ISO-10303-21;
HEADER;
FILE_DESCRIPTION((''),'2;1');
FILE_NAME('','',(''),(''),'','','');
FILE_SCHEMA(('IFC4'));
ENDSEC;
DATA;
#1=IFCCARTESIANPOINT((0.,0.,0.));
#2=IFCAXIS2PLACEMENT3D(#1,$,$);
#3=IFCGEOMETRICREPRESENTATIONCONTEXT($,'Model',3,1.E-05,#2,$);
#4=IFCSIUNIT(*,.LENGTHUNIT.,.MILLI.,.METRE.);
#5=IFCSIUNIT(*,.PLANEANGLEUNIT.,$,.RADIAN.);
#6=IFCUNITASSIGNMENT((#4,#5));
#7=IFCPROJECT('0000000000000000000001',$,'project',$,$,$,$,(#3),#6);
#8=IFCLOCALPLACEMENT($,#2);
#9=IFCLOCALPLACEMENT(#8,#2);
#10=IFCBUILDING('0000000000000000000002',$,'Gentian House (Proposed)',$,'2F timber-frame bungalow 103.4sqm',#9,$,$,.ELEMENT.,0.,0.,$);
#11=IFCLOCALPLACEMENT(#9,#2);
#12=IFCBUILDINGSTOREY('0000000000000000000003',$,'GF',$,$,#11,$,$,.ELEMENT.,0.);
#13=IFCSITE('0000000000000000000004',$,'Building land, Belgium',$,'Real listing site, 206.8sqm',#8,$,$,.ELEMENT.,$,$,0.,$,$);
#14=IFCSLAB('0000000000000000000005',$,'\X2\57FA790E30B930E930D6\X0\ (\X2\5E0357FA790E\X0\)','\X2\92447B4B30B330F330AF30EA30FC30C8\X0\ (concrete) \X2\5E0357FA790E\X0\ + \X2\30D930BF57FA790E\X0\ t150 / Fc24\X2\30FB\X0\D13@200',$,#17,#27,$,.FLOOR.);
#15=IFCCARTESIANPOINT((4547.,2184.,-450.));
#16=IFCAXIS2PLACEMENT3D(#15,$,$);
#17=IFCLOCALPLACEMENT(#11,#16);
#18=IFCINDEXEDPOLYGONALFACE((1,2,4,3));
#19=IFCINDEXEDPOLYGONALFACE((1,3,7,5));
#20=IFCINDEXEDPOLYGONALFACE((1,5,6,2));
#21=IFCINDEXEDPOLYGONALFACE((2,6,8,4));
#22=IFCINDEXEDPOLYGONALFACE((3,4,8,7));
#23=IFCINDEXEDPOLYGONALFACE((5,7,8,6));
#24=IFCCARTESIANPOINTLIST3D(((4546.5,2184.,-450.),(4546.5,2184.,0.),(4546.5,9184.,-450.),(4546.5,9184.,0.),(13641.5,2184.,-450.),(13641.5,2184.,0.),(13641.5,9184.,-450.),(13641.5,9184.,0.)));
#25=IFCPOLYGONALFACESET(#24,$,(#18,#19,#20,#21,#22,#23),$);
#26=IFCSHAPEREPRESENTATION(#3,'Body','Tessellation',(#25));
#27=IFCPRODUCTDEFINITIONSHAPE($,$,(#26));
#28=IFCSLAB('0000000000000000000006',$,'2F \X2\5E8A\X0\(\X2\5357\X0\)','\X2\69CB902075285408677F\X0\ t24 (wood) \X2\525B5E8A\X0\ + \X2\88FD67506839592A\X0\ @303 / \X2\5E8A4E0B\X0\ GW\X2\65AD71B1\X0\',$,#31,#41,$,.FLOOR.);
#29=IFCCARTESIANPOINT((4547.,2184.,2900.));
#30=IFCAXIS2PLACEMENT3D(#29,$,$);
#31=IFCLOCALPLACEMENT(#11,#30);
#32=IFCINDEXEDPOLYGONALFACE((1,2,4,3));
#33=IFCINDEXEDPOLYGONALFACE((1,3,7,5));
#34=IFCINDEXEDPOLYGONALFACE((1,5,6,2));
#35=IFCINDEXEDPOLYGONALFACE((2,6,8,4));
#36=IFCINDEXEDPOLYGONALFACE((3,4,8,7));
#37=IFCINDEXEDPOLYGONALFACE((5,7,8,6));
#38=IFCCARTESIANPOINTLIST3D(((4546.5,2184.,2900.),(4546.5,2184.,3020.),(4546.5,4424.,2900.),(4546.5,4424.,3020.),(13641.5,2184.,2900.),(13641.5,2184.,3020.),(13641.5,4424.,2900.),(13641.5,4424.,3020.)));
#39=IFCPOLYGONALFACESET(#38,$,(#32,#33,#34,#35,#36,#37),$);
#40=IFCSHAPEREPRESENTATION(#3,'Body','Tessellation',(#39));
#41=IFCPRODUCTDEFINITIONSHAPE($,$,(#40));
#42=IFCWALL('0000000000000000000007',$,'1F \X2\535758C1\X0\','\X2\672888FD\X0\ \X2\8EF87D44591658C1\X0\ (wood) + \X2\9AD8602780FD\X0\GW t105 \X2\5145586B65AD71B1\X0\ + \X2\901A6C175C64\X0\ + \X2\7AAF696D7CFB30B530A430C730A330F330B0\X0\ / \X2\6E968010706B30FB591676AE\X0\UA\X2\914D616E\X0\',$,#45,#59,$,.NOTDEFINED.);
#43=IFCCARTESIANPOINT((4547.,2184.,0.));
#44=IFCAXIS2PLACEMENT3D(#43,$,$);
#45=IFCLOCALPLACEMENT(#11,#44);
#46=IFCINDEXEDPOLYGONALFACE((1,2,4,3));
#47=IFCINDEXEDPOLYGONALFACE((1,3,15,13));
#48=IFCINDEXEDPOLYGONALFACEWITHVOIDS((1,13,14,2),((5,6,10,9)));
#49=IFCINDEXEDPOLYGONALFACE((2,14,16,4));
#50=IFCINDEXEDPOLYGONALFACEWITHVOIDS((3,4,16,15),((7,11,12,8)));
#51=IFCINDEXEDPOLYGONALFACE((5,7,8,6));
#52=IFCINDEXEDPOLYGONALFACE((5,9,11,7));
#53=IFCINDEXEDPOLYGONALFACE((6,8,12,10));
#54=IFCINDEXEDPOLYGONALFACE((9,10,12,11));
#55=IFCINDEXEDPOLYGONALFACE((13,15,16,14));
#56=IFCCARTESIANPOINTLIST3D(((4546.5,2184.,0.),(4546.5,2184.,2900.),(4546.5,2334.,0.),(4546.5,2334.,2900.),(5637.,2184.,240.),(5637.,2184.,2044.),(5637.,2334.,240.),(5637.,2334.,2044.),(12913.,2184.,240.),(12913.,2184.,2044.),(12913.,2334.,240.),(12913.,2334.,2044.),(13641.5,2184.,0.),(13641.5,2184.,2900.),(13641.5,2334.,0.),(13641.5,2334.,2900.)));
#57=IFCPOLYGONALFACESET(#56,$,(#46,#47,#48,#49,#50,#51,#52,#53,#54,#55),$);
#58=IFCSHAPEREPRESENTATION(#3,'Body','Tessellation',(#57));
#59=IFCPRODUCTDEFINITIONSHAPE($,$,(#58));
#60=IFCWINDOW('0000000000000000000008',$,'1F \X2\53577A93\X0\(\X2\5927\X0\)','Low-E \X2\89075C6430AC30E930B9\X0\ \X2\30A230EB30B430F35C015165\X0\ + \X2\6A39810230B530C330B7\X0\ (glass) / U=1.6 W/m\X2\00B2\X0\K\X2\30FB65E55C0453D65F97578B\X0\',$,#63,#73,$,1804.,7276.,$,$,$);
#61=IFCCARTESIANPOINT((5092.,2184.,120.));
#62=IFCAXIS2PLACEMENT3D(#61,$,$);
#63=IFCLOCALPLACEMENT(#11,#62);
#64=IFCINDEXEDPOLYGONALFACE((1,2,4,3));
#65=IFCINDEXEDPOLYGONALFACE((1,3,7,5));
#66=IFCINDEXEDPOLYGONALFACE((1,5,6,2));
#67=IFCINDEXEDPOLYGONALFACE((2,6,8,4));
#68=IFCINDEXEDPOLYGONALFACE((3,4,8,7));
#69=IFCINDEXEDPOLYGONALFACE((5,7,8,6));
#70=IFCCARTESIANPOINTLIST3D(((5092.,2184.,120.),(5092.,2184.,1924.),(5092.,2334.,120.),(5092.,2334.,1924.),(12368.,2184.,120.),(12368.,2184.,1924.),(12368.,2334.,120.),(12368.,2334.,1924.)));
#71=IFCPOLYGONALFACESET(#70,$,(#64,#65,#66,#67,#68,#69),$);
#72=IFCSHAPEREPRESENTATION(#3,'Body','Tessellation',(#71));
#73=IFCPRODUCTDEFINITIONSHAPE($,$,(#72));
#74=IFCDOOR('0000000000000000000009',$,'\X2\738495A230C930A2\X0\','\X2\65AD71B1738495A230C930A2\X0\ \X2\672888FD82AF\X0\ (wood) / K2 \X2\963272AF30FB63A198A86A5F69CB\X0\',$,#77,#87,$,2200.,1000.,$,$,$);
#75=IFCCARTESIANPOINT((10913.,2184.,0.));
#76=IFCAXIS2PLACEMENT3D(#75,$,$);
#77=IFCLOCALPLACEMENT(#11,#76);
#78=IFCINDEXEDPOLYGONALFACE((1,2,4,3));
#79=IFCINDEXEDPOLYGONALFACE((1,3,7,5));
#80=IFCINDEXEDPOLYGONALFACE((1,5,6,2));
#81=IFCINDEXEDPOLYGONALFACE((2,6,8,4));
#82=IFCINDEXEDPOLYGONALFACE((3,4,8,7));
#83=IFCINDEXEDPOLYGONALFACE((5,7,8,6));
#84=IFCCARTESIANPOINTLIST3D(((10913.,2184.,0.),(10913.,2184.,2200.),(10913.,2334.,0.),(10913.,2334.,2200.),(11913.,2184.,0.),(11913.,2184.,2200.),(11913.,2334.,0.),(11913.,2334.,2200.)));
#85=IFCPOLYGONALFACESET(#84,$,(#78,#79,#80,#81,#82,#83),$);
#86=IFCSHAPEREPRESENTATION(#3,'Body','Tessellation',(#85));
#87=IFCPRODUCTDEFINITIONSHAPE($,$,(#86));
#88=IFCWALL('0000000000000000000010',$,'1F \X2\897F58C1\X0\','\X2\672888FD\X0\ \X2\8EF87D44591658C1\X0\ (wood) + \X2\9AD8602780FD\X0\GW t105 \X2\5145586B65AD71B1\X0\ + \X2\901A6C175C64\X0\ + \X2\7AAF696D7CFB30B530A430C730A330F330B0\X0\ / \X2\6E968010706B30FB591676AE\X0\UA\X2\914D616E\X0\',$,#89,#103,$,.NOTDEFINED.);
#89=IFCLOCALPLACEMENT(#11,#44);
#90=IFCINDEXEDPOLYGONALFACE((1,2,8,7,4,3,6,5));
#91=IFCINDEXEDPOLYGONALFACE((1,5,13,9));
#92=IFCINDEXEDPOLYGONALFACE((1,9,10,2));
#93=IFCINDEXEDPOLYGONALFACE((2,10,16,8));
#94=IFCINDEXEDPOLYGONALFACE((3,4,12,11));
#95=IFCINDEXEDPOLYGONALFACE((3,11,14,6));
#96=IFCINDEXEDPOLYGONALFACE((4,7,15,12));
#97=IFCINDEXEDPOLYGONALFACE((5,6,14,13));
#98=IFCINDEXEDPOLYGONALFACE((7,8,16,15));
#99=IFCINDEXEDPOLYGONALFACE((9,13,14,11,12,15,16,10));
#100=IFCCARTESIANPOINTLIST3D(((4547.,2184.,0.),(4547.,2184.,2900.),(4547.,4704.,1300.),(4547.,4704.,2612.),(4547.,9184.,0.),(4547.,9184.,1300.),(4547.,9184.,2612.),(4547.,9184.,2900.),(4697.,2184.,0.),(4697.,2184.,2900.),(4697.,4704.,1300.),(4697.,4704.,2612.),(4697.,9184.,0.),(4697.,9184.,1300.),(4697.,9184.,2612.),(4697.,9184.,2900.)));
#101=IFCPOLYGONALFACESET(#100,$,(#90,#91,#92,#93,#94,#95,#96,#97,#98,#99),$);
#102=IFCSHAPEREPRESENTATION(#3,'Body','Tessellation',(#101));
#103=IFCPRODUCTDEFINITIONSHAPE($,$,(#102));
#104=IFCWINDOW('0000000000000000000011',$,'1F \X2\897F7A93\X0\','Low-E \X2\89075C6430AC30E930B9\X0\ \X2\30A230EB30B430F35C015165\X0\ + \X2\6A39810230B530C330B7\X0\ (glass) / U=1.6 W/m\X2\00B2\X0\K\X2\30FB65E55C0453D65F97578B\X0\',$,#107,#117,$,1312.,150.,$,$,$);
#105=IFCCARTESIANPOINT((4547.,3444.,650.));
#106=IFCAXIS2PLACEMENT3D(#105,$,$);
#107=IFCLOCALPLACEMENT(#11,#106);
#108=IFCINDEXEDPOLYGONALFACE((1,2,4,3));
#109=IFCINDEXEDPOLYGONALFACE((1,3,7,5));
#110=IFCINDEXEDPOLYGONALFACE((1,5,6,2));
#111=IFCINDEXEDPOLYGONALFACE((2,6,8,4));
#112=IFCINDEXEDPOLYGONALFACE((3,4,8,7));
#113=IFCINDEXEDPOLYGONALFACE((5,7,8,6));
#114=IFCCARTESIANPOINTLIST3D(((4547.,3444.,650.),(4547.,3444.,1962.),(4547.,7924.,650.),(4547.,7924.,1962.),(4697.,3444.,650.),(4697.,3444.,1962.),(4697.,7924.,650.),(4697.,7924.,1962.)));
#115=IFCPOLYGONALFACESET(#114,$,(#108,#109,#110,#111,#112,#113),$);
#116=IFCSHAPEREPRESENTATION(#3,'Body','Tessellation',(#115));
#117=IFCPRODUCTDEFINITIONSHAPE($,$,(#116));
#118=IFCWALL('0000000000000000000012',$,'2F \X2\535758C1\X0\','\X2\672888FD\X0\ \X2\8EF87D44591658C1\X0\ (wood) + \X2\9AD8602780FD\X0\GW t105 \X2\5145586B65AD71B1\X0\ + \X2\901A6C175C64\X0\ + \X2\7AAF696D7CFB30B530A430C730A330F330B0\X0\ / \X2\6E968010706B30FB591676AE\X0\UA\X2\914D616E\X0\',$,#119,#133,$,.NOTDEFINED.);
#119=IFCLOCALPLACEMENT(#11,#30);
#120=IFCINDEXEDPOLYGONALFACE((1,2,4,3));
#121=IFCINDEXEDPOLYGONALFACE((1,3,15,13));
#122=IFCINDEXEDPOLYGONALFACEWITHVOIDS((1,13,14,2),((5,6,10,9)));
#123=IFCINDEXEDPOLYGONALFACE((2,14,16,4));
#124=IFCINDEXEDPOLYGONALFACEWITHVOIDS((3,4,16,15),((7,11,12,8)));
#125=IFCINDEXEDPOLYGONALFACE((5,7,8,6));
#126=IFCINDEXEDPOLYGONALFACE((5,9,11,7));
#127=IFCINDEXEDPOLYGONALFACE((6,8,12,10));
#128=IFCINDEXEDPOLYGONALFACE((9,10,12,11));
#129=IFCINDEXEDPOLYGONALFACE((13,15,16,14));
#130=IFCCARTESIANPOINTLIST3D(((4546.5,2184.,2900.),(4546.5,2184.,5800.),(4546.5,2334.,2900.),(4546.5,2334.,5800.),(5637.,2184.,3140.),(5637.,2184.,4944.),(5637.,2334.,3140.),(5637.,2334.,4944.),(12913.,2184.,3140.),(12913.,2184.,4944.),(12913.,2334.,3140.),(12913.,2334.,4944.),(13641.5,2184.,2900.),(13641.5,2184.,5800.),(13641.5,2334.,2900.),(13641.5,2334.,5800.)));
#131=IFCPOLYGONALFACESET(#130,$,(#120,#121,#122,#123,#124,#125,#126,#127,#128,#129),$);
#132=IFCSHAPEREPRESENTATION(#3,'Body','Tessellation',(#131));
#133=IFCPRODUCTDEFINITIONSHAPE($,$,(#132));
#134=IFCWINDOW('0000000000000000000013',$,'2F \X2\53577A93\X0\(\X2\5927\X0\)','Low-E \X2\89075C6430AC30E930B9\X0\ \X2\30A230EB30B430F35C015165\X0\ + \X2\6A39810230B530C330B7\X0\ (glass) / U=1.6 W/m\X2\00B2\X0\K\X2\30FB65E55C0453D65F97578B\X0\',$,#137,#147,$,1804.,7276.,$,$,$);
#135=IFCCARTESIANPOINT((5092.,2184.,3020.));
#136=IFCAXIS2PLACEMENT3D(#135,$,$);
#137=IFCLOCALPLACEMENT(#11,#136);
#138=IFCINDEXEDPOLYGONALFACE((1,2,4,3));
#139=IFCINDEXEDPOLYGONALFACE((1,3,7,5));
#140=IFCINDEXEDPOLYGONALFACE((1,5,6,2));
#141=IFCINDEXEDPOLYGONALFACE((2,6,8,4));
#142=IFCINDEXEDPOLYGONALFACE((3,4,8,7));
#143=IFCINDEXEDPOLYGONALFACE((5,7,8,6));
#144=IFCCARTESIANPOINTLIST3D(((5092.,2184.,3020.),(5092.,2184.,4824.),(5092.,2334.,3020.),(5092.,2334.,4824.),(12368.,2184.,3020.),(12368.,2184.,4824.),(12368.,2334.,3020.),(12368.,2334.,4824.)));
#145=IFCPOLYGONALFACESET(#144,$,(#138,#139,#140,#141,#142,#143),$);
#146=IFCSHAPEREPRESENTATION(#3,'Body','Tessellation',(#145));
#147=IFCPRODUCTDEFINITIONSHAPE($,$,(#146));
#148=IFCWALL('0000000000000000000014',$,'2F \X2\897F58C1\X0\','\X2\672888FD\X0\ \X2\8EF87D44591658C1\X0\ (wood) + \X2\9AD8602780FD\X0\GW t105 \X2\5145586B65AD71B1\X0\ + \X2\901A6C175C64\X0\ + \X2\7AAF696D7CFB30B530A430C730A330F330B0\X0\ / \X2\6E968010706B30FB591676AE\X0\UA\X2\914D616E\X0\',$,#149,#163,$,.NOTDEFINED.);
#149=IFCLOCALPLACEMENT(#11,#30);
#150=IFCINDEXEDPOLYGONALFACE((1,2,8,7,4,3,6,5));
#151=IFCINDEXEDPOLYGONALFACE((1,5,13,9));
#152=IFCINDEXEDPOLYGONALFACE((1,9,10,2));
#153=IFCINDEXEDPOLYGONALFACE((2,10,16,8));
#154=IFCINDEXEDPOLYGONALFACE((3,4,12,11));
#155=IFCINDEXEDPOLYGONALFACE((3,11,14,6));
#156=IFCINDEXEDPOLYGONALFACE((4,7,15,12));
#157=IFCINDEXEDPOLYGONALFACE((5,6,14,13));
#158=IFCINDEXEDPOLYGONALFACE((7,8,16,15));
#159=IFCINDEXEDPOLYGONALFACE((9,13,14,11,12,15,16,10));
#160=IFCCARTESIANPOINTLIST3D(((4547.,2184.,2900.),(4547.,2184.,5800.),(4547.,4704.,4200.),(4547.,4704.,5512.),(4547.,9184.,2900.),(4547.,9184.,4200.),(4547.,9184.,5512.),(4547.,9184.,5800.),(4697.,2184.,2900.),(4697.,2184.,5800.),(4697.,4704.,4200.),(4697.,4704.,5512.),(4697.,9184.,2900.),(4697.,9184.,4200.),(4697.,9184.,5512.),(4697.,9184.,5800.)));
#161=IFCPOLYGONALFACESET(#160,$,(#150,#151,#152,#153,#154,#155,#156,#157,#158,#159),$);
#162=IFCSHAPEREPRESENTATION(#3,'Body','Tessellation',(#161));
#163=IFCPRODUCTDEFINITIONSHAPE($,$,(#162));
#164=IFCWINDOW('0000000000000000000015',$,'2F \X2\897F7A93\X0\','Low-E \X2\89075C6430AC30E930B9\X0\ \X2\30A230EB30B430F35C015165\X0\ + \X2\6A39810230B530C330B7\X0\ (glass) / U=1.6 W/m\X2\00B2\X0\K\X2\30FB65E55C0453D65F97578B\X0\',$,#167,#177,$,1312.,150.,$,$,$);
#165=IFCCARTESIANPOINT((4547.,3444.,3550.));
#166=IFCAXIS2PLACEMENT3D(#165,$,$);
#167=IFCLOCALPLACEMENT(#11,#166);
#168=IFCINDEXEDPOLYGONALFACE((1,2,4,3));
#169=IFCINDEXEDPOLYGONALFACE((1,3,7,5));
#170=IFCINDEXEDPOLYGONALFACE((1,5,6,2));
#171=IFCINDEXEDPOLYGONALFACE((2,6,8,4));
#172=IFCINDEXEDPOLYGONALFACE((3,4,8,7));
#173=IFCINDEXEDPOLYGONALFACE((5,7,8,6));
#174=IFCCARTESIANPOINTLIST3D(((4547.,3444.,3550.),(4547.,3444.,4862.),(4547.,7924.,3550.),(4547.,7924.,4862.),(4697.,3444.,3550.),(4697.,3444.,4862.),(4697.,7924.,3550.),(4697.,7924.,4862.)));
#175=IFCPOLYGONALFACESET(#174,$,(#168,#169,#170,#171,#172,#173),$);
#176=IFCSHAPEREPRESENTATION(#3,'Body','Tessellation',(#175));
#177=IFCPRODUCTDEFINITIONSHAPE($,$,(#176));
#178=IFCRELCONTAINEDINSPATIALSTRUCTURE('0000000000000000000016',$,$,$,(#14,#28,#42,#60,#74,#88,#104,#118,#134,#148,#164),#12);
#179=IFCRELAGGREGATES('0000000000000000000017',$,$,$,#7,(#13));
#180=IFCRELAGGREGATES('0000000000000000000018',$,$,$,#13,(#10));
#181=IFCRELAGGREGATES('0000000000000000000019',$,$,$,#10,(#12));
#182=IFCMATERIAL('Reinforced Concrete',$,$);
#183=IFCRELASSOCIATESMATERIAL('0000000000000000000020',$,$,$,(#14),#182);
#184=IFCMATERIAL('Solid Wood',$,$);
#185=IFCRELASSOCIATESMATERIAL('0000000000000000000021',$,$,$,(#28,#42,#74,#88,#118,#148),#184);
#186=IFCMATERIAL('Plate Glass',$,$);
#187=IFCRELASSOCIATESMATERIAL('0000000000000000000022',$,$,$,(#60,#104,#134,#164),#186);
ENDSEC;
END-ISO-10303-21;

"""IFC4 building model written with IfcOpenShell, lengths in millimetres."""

from ifc_helpers import new_model, si_unit, frame, frame_2d, origin, place, context, project, spatial, rectangle, extrude, material, element, fill, save


model = new_model("IFC4")

# Units and contexts
model_context = context("Model", 3, precision=1e-05, world=origin())
ifc_project = project(units=[si_unit("LENGTHUNIT", "METRE", prefix="MILLI"), si_unit("PLANEANGLEUNIT", "RADIAN")], contexts=[model_context])

# Site, building, storey
site_placement = place(None, origin())
site = spatial("IfcSite", under=ifc_project, at=site_placement, Name="Building land, Belgium", ObjectType="Real listing site, 206.8sqm", CompositionType="ELEMENT", RefElevation=0.0)
building_placement = place(site_placement, origin())
building = spatial("IfcBuilding", under=site, at=building_placement, Name="Gentian House (Proposed)", ObjectType="2F timber-frame bungalow 103.4sqm", CompositionType="ELEMENT", ElevationOfRefHeight=0.0, ElevationOfTerrain=0.0)
storey_placement = place(building_placement, origin())
storey = spatial("IfcBuildingStorey", under=building, at=storey_placement, Name="GF", CompositionType="ELEMENT", Elevation=0.0)

# Slabs
ifc_material_1 = material(Name="Reinforced Concrete")
slab_1_placement = place(storey_placement, frame((4547.0, 2184.0, -450.0)))
element("IfcSlab", 1, at=slab_1_placement, inside=storey, material=ifc_material_1, Name="基礎スラブ (布基礎)", Description="鉄筋コンクリート (concrete) 布基礎 + ベタ基礎 t150 / Fc24・D13@200", PredefinedType="FLOOR", context=model_context, shape_type="SweptSolid", body=[
    extrude(rectangle(XDim=9095.0, YDim=7000.0, at=frame_2d((4547.0, 3500.0))), frame((4547.0, 2184.0, -450.0)), (0.0, 0.0, 1.0), 450.0),
])
ifc_material_2 = material(Name="Solid Wood")
slab_2_placement = place(storey_placement, frame((4547.0, 2184.0, 2900.0)))
element("IfcSlab", 2, at=slab_2_placement, inside=storey, material=ifc_material_2, Name="2F 床(南)", Description="構造用合板 t24 (wood) 剛床 + 製材根太 @303 / 床下 GW断熱", PredefinedType="FLOOR", context=model_context, shape_type="SweptSolid", body=[
    extrude(rectangle(XDim=9095.0, YDim=2240.0, at=frame_2d((4547.0, 1120.0))), frame((4547.0, 2184.0, 2900.0)), (0.0, 0.0, 1.0), 120.0),
])

# Wall, openings, window, door
wall_1_placement = place(storey_placement, frame((4547.0, 2184.0, 0.0)))
wall_1 = element("IfcWall", 3, at=wall_1_placement, inside=storey, material=ifc_material_2, Name="1F 南壁", Description="木製 軸組外壁 (wood) + 高性能GW t105 充填断熱 + 通気層 + 窯業系サイディング / 準耐火・外皮UA配慮", PredefinedType="NOTDEFINED", context=model_context, shape_type="SweptSolid", body=[
    extrude(rectangle(XDim=9095.0, YDim=150.0, at=frame_2d((4547.0, 75.0))), frame((4547.0, 2184.0, 0.0)), (0.0, 0.0, 1.0), 2900.0),
])
opening_1_placement = place(storey_placement, frame((5092.0, 2184.0, 120.0)))
opening_1 = element("IfcOpeningElement", 4, at=opening_1_placement, cuts=wall_1, PredefinedType="NOTDEFINED", context=model_context, shape_type="SweptSolid", body=[
    extrude(rectangle(XDim=7276.0, YDim=150.0, at=frame_2d((3638.0, 75.0))), frame((5092.0, 2184.0, 120.0)), (0.0, 0.0, 1.0), 1804.0),
])
opening_2_placement = place(storey_placement, frame((10913.0, 2184.0, 0.0)))
opening_2 = element("IfcOpeningElement", 5, at=opening_2_placement, cuts=wall_1, PredefinedType="NOTDEFINED", context=model_context, shape_type="SweptSolid", body=[
    extrude(rectangle(XDim=1000.0, YDim=150.0, at=frame_2d((500.0, 75.0))), frame((10913.0, 2184.0, 0.0)), (0.0, 0.0, 1.0), 2200.0),
])
ifc_material_3 = material(Name="Plate Glass")
window_1_placement = place(storey_placement, frame((5092.0, 2184.0, 120.0)))
window_1 = element("IfcWindow", 6, at=window_1_placement, inside=storey, material=ifc_material_3, Name="1F 南窓(大)", Description="Low-E 複層ガラス アルゴン封入 + 樹脂サッシ (glass) / U=1.6 W/m²K・日射取得型", OverallHeight=1804.0, OverallWidth=7276.0, context=model_context, shape_type="SweptSolid", body=[
    extrude(rectangle(XDim=7276.0, YDim=150.0, at=frame_2d((3638.0, 75.0))), frame((5092.0, 2184.0, 120.0)), (0.0, 0.0, 1.0), 1804.0),
])
fill(opening_1, window_1)
door_placement = place(storey_placement, frame((10913.0, 2184.0, 0.0)))
door = element("IfcDoor", 7, at=door_placement, inside=storey, material=ifc_material_2, Name="玄関ドア", Description="断熱玄関ドア 木製芯 (wood) / K2 防犯・採風機構", OverallHeight=2200.0, OverallWidth=1000.0, context=model_context, shape_type="SweptSolid", body=[
    extrude(rectangle(XDim=1000.0, YDim=150.0, at=frame_2d((500.0, 75.0))), frame((10913.0, 2184.0, 0.0)), (0.0, 0.0, 1.0), 2200.0),
])
fill(opening_2, door)

# Walls, openings, windows
wall_2_placement = place(storey_placement, frame((4547.0, 2184.0, 0.0)))
wall_2 = element("IfcWall", 8, at=wall_2_placement, inside=storey, material=ifc_material_2, Name="1F 西壁", Description="木製 軸組外壁 (wood) + 高性能GW t105 充填断熱 + 通気層 + 窯業系サイディング / 準耐火・外皮UA配慮", PredefinedType="NOTDEFINED", context=model_context, shape_type="SweptSolid", body=[
    extrude(rectangle(XDim=150.0, YDim=7000.0, at=frame_2d((75.0, 3500.0))), frame((4547.0, 2184.0, 0.0)), (0.0, 0.0, 1.0), 2900.0),
])
opening_3_placement = place(storey_placement, frame((4547.0, 3444.0, 650.0)))
opening_3 = element("IfcOpeningElement", 9, at=opening_3_placement, cuts=wall_2, PredefinedType="NOTDEFINED", context=model_context, shape_type="SweptSolid", body=[
    extrude(rectangle(XDim=150.0, YDim=4480.0, at=frame_2d((75.0, 2240.0))), frame((4547.0, 3444.0, 650.0)), (0.0, 0.0, 1.0), 1312.0),
])
window_2_placement = place(storey_placement, frame((4547.0, 3444.0, 650.0)))
window_2 = element("IfcWindow", 10, at=window_2_placement, inside=storey, material=ifc_material_3, Name="1F 西窓", Description="Low-E 複層ガラス アルゴン封入 + 樹脂サッシ (glass) / U=1.6 W/m²K・日射取得型", OverallHeight=1312.0, OverallWidth=150.0, context=model_context, shape_type="SweptSolid", body=[
    extrude(rectangle(XDim=150.0, YDim=4480.0, at=frame_2d((75.0, 2240.0))), frame((4547.0, 3444.0, 650.0)), (0.0, 0.0, 1.0), 1312.0),
])
fill(opening_3, window_2)
wall_3_placement = place(storey_placement, frame((4547.0, 2184.0, 2900.0)))
wall_3 = element("IfcWall", 11, at=wall_3_placement, inside=storey, material=ifc_material_2, Name="2F 南壁", Description="木製 軸組外壁 (wood) + 高性能GW t105 充填断熱 + 通気層 + 窯業系サイディング / 準耐火・外皮UA配慮", PredefinedType="NOTDEFINED", context=model_context, shape_type="SweptSolid", body=[
    extrude(rectangle(XDim=9095.0, YDim=150.0, at=frame_2d((4547.0, 75.0))), frame((4547.0, 2184.0, 2900.0)), (0.0, 0.0, 1.0), 2900.0),
])
opening_4_placement = place(storey_placement, frame((5092.0, 2184.0, 3020.0)))
opening_4 = element("IfcOpeningElement", 12, at=opening_4_placement, cuts=wall_3, PredefinedType="NOTDEFINED", context=model_context, shape_type="SweptSolid", body=[
    extrude(rectangle(XDim=7276.0, YDim=150.0, at=frame_2d((3638.0, 75.0))), frame((5092.0, 2184.0, 3020.0)), (0.0, 0.0, 1.0), 1804.0),
])
window_3_placement = place(storey_placement, frame((5092.0, 2184.0, 3020.0)))
window_3 = element("IfcWindow", 13, at=window_3_placement, inside=storey, material=ifc_material_3, Name="2F 南窓(大)", Description="Low-E 複層ガラス アルゴン封入 + 樹脂サッシ (glass) / U=1.6 W/m²K・日射取得型", OverallHeight=1804.0, OverallWidth=7276.0, context=model_context, shape_type="SweptSolid", body=[
    extrude(rectangle(XDim=7276.0, YDim=150.0, at=frame_2d((3638.0, 75.0))), frame((5092.0, 2184.0, 3020.0)), (0.0, 0.0, 1.0), 1804.0),
])
fill(opening_4, window_3)
wall_4_placement = place(storey_placement, frame((4547.0, 2184.0, 2900.0)))
wall_4 = element("IfcWall", 14, at=wall_4_placement, inside=storey, material=ifc_material_2, Name="2F 西壁", Description="木製 軸組外壁 (wood) + 高性能GW t105 充填断熱 + 通気層 + 窯業系サイディング / 準耐火・外皮UA配慮", PredefinedType="NOTDEFINED", context=model_context, shape_type="SweptSolid", body=[
    extrude(rectangle(XDim=150.0, YDim=7000.0, at=frame_2d((75.0, 3500.0))), frame((4547.0, 2184.0, 2900.0)), (0.0, 0.0, 1.0), 2900.0),
])
opening_5_placement = place(storey_placement, frame((4547.0, 3444.0, 3550.0)))
opening_5 = element("IfcOpeningElement", 15, at=opening_5_placement, cuts=wall_4, PredefinedType="NOTDEFINED", context=model_context, shape_type="SweptSolid", body=[
    extrude(rectangle(XDim=150.0, YDim=4480.0, at=frame_2d((75.0, 2240.0))), frame((4547.0, 3444.0, 3550.0)), (0.0, 0.0, 1.0), 1312.0),
])
window_4_placement = place(storey_placement, frame((4547.0, 3444.0, 3550.0)))
window_4 = element("IfcWindow", 16, at=window_4_placement, inside=storey, material=ifc_material_3, Name="2F 西窓", Description="Low-E 複層ガラス アルゴン封入 + 樹脂サッシ (glass) / U=1.6 W/m²K・日射取得型", OverallHeight=1312.0, OverallWidth=150.0, context=model_context, shape_type="SweptSolid", body=[
    extrude(rectangle(XDim=150.0, YDim=4480.0, at=frame_2d((75.0, 2240.0))), frame((4547.0, 3444.0, 3550.0)), (0.0, 0.0, 1.0), 1312.0),
])
fill(opening_5, window_4)

save(model, "model.ifc")
